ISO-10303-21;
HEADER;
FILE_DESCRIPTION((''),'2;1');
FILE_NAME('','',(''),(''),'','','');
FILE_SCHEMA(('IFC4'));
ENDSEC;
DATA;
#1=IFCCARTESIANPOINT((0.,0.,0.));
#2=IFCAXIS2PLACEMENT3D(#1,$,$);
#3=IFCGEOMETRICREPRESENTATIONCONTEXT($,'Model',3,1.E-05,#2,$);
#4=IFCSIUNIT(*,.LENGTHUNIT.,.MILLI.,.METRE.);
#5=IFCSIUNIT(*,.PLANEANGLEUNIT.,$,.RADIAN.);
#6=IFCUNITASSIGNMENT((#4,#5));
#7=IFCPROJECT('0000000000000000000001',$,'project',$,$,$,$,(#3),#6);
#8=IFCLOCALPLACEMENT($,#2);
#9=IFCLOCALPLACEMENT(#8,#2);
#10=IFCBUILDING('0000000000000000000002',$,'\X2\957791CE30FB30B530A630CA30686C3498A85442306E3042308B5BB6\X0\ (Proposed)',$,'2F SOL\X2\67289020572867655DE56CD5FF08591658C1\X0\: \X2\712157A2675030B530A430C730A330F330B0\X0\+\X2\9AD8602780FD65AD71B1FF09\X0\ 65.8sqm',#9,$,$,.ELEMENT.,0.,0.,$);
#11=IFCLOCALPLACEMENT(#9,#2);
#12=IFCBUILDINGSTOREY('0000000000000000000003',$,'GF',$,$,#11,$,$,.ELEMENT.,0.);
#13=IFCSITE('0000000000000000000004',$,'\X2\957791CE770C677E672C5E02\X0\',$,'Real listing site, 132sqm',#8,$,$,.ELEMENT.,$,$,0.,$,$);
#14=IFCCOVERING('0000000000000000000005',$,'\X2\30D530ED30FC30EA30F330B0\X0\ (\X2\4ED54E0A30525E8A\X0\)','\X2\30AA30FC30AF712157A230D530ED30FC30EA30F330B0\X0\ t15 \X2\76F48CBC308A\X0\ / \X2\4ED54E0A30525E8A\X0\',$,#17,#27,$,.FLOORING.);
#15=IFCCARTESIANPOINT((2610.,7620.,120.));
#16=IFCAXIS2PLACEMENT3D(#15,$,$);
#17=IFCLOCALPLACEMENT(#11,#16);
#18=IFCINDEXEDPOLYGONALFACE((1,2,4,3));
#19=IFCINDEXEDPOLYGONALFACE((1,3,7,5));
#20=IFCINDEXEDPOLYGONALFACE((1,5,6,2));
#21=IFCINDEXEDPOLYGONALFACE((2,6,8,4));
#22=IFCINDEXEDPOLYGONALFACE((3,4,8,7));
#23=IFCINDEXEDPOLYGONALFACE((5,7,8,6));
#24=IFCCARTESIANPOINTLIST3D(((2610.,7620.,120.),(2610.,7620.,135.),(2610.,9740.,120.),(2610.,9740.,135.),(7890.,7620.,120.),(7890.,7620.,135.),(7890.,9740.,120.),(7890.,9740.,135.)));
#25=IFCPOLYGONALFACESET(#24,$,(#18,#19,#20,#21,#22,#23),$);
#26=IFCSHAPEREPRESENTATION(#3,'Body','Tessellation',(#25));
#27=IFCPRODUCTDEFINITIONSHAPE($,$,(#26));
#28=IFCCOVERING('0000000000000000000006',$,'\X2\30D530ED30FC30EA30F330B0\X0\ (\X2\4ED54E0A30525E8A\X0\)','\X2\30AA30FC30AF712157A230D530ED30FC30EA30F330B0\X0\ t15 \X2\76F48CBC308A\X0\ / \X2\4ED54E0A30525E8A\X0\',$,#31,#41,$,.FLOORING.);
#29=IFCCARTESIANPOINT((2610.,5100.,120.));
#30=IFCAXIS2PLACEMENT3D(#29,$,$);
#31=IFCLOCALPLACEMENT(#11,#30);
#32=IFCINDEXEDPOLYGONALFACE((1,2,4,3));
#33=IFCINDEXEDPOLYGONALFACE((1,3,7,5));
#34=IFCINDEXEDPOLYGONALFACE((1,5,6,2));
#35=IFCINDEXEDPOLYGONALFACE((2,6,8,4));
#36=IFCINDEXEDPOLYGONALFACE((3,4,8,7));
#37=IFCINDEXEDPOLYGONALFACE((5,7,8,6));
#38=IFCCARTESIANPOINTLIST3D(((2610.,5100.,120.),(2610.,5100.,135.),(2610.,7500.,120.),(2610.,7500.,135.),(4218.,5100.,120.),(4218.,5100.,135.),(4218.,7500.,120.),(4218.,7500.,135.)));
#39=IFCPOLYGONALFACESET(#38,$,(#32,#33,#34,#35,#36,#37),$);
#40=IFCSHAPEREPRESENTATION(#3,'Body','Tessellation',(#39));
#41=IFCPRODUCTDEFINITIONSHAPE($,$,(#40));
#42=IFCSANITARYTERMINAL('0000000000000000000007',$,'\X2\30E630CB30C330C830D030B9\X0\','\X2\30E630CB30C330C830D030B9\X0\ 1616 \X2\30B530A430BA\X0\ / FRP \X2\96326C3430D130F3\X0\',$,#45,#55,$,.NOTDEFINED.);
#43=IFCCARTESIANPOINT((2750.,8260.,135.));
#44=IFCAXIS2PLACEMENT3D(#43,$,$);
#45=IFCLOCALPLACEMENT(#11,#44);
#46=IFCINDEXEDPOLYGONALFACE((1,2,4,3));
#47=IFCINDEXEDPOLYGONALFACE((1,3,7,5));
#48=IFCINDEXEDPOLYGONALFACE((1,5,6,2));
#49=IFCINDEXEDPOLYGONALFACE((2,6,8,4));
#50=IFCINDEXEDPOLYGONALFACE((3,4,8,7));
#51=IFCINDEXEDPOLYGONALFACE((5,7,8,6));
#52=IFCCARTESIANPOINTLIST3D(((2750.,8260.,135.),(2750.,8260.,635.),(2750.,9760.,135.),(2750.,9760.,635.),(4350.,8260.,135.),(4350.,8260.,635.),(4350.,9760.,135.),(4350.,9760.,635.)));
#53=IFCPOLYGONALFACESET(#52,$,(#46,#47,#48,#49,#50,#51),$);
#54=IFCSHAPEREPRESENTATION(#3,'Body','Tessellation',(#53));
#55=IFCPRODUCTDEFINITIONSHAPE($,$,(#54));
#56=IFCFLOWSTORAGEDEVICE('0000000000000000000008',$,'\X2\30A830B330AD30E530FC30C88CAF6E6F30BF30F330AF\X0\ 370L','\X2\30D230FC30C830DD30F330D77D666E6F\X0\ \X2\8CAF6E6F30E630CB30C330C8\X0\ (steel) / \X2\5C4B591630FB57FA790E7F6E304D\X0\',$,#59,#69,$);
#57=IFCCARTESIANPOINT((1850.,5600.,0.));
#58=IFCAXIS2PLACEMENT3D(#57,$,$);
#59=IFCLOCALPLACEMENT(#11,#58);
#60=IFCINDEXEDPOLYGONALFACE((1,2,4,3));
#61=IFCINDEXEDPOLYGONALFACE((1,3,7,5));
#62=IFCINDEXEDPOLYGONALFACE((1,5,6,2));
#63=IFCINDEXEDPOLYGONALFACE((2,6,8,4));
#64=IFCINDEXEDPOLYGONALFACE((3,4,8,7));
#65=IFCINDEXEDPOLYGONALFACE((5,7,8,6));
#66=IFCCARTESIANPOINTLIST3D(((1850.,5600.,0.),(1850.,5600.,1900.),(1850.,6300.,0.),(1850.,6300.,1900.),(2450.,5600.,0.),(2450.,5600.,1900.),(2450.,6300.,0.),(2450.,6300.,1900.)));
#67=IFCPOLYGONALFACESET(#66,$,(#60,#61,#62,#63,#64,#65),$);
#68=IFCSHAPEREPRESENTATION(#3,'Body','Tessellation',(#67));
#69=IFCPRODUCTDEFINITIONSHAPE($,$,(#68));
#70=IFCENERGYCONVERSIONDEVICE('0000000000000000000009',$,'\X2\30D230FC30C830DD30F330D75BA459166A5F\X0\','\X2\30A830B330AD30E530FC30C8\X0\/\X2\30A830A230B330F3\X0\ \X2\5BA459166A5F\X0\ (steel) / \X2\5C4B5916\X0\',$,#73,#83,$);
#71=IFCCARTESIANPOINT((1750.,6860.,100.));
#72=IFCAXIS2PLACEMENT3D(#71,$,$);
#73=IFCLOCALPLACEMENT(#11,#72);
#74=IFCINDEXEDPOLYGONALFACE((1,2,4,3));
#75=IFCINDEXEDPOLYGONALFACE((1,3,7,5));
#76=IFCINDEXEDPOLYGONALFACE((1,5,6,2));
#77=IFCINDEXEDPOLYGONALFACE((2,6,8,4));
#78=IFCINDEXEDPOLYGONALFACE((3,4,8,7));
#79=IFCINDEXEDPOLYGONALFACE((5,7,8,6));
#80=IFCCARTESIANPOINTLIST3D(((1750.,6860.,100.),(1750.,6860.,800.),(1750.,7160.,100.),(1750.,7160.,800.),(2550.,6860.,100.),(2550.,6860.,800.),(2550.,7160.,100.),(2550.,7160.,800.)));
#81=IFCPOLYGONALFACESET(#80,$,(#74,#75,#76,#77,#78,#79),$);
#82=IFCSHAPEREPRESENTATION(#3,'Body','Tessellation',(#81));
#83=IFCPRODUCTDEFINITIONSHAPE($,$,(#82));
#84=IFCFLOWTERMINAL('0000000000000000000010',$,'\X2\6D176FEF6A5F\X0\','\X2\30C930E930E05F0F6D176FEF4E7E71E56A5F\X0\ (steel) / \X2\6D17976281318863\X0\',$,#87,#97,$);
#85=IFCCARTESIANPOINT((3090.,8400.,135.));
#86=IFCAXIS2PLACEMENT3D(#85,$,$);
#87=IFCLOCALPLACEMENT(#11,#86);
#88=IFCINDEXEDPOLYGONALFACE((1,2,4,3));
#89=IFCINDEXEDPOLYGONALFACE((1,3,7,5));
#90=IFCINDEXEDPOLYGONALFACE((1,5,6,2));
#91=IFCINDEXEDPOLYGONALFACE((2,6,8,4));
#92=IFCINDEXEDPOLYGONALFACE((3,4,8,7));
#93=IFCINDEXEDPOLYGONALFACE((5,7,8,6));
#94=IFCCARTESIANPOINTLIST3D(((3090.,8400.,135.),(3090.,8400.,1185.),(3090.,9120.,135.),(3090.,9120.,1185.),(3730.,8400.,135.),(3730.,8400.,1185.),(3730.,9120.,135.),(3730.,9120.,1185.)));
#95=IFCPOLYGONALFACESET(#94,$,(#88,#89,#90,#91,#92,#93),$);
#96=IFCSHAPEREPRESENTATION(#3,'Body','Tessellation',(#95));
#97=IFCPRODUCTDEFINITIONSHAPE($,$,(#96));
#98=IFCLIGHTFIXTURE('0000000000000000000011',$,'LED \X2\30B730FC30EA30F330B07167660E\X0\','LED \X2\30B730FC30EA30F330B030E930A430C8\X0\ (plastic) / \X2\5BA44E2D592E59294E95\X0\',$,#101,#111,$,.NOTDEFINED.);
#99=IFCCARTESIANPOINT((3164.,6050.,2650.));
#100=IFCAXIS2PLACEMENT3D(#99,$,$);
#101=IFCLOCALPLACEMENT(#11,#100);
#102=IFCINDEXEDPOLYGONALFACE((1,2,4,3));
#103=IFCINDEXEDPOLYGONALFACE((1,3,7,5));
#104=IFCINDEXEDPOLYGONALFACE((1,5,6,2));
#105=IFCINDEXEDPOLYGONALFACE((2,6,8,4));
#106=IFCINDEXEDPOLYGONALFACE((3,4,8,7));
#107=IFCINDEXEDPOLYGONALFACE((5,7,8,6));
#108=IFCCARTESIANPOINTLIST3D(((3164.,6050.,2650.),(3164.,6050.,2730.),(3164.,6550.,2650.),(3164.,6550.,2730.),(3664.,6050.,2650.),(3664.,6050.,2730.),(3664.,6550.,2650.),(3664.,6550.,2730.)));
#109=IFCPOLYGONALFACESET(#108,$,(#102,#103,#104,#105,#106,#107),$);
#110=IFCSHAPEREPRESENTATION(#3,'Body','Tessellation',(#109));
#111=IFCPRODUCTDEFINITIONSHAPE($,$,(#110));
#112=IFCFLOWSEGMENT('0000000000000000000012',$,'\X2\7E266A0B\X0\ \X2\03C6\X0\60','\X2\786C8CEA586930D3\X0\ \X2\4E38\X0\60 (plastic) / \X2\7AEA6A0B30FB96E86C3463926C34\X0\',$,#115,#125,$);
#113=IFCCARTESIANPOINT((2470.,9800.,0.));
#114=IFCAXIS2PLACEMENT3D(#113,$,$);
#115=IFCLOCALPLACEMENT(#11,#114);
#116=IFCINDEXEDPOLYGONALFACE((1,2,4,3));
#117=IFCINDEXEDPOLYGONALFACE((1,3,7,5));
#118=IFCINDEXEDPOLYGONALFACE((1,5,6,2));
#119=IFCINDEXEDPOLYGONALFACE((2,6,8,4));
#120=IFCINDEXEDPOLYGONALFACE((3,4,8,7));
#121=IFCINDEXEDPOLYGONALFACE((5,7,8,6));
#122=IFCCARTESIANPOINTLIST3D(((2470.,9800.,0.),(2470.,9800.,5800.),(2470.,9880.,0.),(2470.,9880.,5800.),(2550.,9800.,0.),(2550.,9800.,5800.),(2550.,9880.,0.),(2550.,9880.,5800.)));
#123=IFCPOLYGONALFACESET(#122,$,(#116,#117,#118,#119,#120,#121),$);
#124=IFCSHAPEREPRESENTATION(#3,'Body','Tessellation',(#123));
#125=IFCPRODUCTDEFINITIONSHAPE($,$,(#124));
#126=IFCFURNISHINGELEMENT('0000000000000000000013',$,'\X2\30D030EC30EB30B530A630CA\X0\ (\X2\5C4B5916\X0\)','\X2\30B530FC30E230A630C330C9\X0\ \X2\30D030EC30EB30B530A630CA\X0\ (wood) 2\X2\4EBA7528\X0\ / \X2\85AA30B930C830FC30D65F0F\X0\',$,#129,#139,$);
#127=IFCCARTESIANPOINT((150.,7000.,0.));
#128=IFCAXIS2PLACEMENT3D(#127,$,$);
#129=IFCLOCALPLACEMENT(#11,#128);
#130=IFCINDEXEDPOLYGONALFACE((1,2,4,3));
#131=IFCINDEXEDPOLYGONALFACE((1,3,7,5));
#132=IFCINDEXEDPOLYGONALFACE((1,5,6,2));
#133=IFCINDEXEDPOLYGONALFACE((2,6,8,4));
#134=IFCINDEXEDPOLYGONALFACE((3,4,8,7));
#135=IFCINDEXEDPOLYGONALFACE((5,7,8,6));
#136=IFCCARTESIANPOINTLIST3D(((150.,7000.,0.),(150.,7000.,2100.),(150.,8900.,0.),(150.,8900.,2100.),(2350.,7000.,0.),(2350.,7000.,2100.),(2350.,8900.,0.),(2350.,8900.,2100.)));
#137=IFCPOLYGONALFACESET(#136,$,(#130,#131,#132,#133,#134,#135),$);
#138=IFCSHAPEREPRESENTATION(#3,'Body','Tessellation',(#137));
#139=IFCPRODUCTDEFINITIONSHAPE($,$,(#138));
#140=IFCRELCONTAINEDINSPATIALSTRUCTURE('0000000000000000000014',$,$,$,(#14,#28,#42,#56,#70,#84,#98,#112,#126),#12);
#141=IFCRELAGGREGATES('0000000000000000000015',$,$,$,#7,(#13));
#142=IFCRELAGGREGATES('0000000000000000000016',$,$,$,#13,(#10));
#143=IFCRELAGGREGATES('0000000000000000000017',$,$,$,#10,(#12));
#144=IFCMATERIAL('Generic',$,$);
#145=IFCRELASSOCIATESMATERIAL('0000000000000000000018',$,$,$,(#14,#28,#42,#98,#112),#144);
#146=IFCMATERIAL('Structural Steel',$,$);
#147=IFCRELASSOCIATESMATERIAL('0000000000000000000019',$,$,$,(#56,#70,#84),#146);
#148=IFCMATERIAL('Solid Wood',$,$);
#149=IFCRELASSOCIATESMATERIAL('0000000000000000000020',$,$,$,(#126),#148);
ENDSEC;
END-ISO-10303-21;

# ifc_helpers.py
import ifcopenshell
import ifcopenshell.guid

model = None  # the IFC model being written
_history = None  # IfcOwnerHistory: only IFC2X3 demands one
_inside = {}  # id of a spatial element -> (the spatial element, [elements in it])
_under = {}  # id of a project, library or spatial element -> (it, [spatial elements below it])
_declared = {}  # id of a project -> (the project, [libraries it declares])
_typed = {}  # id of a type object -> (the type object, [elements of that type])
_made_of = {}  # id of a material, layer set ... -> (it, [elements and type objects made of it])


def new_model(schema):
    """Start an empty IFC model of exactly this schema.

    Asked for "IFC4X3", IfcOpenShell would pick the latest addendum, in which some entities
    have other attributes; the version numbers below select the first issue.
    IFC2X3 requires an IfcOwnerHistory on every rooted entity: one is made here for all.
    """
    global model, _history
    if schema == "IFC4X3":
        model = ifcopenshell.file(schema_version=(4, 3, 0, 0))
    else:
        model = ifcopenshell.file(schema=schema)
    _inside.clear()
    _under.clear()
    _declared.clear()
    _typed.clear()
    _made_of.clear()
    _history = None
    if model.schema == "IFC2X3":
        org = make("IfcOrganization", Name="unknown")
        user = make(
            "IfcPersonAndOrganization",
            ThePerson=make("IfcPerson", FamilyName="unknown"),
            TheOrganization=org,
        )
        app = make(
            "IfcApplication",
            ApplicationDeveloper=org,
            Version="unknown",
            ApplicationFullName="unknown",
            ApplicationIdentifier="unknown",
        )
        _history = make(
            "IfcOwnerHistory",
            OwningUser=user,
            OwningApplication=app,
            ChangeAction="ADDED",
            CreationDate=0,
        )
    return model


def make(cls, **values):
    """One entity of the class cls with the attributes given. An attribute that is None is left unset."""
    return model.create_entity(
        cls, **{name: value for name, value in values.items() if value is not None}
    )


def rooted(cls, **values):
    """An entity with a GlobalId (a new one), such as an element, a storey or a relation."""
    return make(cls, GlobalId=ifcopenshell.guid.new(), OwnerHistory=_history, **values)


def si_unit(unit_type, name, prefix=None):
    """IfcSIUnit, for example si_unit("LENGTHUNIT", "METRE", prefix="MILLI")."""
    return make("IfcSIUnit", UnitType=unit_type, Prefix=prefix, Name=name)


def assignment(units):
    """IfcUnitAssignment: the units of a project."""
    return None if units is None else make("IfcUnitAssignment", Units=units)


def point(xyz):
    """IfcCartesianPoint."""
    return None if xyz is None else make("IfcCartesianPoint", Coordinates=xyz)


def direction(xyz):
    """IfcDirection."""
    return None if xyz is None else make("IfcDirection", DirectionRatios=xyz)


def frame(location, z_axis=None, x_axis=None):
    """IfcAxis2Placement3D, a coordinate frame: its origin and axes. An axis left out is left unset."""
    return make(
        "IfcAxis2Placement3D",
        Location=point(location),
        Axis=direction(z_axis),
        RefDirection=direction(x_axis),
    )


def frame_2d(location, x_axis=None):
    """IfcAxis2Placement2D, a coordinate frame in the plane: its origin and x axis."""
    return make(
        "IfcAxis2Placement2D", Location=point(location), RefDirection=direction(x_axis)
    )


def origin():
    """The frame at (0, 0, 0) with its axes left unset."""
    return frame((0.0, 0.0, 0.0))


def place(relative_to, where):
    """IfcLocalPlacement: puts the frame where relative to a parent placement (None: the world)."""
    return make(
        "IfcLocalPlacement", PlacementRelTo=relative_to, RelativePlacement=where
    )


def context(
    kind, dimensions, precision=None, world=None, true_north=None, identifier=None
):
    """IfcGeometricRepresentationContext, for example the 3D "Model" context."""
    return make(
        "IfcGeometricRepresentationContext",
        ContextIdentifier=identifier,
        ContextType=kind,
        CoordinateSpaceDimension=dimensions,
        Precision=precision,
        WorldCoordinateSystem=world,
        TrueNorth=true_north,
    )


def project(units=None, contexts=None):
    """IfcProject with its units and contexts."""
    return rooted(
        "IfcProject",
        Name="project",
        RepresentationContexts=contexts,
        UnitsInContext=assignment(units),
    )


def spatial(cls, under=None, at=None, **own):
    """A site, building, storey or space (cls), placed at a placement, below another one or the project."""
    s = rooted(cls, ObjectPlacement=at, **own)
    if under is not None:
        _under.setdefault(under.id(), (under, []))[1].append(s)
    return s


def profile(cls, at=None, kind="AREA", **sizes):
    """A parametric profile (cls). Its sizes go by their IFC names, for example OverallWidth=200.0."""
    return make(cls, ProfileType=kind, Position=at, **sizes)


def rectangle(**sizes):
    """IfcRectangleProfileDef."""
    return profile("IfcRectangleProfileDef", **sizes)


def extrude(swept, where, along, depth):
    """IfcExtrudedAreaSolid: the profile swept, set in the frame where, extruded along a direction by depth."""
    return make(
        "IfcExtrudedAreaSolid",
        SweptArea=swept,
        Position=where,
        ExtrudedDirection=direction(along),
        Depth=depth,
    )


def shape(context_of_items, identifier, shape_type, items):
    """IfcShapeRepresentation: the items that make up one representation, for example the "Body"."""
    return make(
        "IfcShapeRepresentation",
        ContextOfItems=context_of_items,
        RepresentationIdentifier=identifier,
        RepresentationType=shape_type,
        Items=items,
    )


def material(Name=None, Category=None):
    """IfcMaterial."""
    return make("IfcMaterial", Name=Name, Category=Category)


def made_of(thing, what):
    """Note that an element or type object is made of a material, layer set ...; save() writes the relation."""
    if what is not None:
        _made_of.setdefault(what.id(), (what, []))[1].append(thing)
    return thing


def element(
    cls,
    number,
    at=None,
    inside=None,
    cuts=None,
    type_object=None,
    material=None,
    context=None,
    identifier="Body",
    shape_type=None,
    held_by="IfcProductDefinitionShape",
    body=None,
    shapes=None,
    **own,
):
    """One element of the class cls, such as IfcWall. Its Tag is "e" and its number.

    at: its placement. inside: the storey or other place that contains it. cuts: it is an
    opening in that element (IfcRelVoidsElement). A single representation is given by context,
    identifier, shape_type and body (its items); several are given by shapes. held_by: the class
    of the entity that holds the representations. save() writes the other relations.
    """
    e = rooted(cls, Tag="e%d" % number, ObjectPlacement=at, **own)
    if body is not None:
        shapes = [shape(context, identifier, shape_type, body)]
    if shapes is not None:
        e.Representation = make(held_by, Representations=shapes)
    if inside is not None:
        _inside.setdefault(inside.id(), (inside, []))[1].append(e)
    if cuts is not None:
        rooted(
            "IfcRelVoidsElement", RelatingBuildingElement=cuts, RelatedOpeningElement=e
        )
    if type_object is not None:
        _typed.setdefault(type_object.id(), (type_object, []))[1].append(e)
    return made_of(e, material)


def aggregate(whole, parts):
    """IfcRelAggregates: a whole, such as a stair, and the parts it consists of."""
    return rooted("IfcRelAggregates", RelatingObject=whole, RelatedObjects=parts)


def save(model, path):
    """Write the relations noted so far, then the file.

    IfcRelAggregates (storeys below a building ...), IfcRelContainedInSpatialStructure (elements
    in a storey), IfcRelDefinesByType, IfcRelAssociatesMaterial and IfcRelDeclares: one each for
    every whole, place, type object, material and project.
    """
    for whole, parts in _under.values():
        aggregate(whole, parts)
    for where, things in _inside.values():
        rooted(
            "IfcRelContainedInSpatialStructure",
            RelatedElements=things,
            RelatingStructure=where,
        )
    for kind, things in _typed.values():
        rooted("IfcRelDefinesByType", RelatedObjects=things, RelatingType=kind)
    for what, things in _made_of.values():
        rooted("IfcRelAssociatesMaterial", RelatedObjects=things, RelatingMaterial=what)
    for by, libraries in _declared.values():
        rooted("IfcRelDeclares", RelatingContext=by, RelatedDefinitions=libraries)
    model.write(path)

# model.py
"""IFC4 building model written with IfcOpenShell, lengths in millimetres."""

from ifc_helpers import new_model, si_unit, frame, frame_2d, origin, place, context, project, spatial, rectangle, extrude, material, element, save


model = new_model("IFC4")

# Units and contexts
model_context = context("Model", 3, precision=1e-05, world=origin())
ifc_project = project(units=[si_unit("LENGTHUNIT", "METRE", prefix="MILLI"), si_unit("PLANEANGLEUNIT", "RADIAN")], contexts=[model_context])

# Site, building, storey
site_placement = place(None, origin())
site = spatial("IfcSite", under=ifc_project, at=site_placement, Name="長野県松本市", ObjectType="Real listing site, 132sqm", CompositionType="ELEMENT", RefElevation=0.0)
building_placement = place(site_placement, origin())
building = spatial("IfcBuilding", under=site, at=building_placement, Name="長野・サウナと水風呂のある家 (Proposed)", ObjectType="2F SOL木造在来工法（外壁: 無垢材サイディング+高性能断熱） 65.8sqm", CompositionType="ELEMENT", ElevationOfRefHeight=0.0, ElevationOfTerrain=0.0)
storey_placement = place(building_placement, origin())
storey = spatial("IfcBuildingStorey", under=building, at=storey_placement, Name="GF", CompositionType="ELEMENT", Elevation=0.0)

# Shared definitions
ifc_material_1 = material(Name="Solid Wood")

# Coverings
ifc_material_2 = material(Name="Generic")
covering_1_placement = place(storey_placement, frame((2610.0, 7620.0, 120.0)))
element("IfcCovering", 1, at=covering_1_placement, inside=storey, material=ifc_material_2, Name="フローリング (仕上げ床)", Description="オーク無垢フローリング t15 直貼り / 仕上げ床", PredefinedType="FLOORING", context=model_context, shape_type="SweptSolid", body=[
    extrude(rectangle(XDim=5280.0, YDim=2120.0, at=frame_2d((2640.0, 1060.0))), frame((2610.0, 7620.0, 120.0)), (0.0, 0.0, 1.0), 15.0),
])
covering_2_placement = place(storey_placement, frame((2610.0, 5100.0, 120.0)))
element("IfcCovering", 2, at=covering_2_placement, inside=storey, material=ifc_material_2, Name="フローリング (仕上げ床)", Description="オーク無垢フローリング t15 直貼り / 仕上げ床", PredefinedType="FLOORING", context=model_context, shape_type="SweptSolid", body=[
    extrude(rectangle(XDim=1608.0, YDim=2400.0, at=frame_2d((804.0, 1200.0))), frame((2610.0, 5100.0, 120.0)), (0.0, 0.0, 1.0), 15.0),
])

# Sanitary terminal
sanitary_terminal_placement = place(storey_placement, frame((2750.0, 8260.0, 135.0)))
element("IfcSanitaryTerminal", 3, at=sanitary_terminal_placement, inside=storey, material=ifc_material_2, Name="ユニットバス", Description="ユニットバス 1616 サイズ / FRP 防水パン", PredefinedType="NOTDEFINED", context=model_context, shape_type="SweptSolid", body=[
    extrude(rectangle(XDim=1600.0, YDim=1500.0, at=frame_2d((800.0, 750.0))), frame((2750.0, 8260.0, 135.0)), (0.0, 0.0, 1.0), 500.0),
])

# Flow storage device
ifc_material_3 = material(Name="Structural Steel")
flow_storage_device_placement = place(storey_placement, frame((1850.0, 5600.0, 0.0)))
element("IfcFlowStorageDevice", 4, at=flow_storage_device_placement, inside=storey, material=ifc_material_3, Name="エコキュート貯湯タンク 370L", Description="ヒートポンプ給湯 貯湯ユニット (steel) / 屋外・基礎置き", context=model_context, shape_type="SweptSolid", body=[
    extrude(rectangle(XDim=600.0, YDim=700.0, at=frame_2d((300.0, 350.0))), frame((1850.0, 5600.0, 0.0)), (0.0, 0.0, 1.0), 1900.0),
])

# Energy conversion device
energy_conversion_device_placement = place(storey_placement, frame((1750.0, 6860.0, 100.0)))
element("IfcEnergyConversionDevice", 5, at=energy_conversion_device_placement, inside=storey, material=ifc_material_3, Name="ヒートポンプ室外機", Description="エコキュート/エアコン 室外機 (steel) / 屋外", context=model_context, shape_type="SweptSolid", body=[
    extrude(rectangle(XDim=800.0, YDim=300.0, at=frame_2d((400.0, 150.0))), frame((1750.0, 6860.0, 100.0)), (0.0, 0.0, 1.0), 700.0),
])

# Flow terminal
flow_terminal_placement = place(storey_placement, frame((3090.0, 8400.0, 135.0)))
element("IfcFlowTerminal", 6, at=flow_terminal_placement, inside=storey, material=ifc_material_3, Name="洗濯機", Description="ドラム式洗濯乾燥機 (steel) / 洗面脱衣", context=model_context, shape_type="SweptSolid", body=[
    extrude(rectangle(XDim=640.0, YDim=720.0, at=frame_2d((320.0, 360.0))), frame((3090.0, 8400.0, 135.0)), (0.0, 0.0, 1.0), 1050.0),
])

# Light fixture
light_fixture_placement = place(storey_placement, frame((3164.0, 6050.0, 2650.0)))
element("IfcLightFixture", 7, at=light_fixture_placement, inside=storey, material=ifc_material_2, Name="LED シーリング照明", Description="LED シーリングライト (plastic) / 室中央天井", PredefinedType="NOTDEFINED", context=model_context, shape_type="SweptSolid", body=[
    extrude(rectangle(XDim=500.0, YDim=500.0, at=frame_2d((250.0, 250.0))), frame((3164.0, 6050.0, 2650.0)), (0.0, 0.0, 1.0), 80.0),
])

# Flow segment
flow_segment_placement = place(storey_placement, frame((2470.0, 9800.0, 0.0)))
element("IfcFlowSegment", 8, at=flow_segment_placement, inside=storey, material=ifc_material_2, Name="縦樋 φ60", Description="硬質塩ビ 丸60 (plastic) / 竪樋・雨水排水", context=model_context, shape_type="SweptSolid", body=[
    extrude(rectangle(XDim=80.0, YDim=80.0, at=frame_2d((40.0, 40.0))), frame((2470.0, 9800.0, 0.0)), (0.0, 0.0, 1.0), 5800.0),
])

# Furnishing element
furnishing_placement = place(storey_placement, frame((150.0, 7000.0, 0.0)))
element("IfcFurnishingElement", 9, at=furnishing_placement, inside=storey, material=ifc_material_1, Name="バレルサウナ (屋外)", Description="サーモウッド バレルサウナ (wood) 2人用 / 薪ストーブ式", context=model_context, shape_type="SweptSolid", body=[
    extrude(rectangle(XDim=2200.0, YDim=1900.0, at=frame_2d((1100.0, 950.0))), frame((150.0, 7000.0, 0.0)), (0.0, 0.0, 1.0), 2100.0),
])

save(model, "model.ifc")
